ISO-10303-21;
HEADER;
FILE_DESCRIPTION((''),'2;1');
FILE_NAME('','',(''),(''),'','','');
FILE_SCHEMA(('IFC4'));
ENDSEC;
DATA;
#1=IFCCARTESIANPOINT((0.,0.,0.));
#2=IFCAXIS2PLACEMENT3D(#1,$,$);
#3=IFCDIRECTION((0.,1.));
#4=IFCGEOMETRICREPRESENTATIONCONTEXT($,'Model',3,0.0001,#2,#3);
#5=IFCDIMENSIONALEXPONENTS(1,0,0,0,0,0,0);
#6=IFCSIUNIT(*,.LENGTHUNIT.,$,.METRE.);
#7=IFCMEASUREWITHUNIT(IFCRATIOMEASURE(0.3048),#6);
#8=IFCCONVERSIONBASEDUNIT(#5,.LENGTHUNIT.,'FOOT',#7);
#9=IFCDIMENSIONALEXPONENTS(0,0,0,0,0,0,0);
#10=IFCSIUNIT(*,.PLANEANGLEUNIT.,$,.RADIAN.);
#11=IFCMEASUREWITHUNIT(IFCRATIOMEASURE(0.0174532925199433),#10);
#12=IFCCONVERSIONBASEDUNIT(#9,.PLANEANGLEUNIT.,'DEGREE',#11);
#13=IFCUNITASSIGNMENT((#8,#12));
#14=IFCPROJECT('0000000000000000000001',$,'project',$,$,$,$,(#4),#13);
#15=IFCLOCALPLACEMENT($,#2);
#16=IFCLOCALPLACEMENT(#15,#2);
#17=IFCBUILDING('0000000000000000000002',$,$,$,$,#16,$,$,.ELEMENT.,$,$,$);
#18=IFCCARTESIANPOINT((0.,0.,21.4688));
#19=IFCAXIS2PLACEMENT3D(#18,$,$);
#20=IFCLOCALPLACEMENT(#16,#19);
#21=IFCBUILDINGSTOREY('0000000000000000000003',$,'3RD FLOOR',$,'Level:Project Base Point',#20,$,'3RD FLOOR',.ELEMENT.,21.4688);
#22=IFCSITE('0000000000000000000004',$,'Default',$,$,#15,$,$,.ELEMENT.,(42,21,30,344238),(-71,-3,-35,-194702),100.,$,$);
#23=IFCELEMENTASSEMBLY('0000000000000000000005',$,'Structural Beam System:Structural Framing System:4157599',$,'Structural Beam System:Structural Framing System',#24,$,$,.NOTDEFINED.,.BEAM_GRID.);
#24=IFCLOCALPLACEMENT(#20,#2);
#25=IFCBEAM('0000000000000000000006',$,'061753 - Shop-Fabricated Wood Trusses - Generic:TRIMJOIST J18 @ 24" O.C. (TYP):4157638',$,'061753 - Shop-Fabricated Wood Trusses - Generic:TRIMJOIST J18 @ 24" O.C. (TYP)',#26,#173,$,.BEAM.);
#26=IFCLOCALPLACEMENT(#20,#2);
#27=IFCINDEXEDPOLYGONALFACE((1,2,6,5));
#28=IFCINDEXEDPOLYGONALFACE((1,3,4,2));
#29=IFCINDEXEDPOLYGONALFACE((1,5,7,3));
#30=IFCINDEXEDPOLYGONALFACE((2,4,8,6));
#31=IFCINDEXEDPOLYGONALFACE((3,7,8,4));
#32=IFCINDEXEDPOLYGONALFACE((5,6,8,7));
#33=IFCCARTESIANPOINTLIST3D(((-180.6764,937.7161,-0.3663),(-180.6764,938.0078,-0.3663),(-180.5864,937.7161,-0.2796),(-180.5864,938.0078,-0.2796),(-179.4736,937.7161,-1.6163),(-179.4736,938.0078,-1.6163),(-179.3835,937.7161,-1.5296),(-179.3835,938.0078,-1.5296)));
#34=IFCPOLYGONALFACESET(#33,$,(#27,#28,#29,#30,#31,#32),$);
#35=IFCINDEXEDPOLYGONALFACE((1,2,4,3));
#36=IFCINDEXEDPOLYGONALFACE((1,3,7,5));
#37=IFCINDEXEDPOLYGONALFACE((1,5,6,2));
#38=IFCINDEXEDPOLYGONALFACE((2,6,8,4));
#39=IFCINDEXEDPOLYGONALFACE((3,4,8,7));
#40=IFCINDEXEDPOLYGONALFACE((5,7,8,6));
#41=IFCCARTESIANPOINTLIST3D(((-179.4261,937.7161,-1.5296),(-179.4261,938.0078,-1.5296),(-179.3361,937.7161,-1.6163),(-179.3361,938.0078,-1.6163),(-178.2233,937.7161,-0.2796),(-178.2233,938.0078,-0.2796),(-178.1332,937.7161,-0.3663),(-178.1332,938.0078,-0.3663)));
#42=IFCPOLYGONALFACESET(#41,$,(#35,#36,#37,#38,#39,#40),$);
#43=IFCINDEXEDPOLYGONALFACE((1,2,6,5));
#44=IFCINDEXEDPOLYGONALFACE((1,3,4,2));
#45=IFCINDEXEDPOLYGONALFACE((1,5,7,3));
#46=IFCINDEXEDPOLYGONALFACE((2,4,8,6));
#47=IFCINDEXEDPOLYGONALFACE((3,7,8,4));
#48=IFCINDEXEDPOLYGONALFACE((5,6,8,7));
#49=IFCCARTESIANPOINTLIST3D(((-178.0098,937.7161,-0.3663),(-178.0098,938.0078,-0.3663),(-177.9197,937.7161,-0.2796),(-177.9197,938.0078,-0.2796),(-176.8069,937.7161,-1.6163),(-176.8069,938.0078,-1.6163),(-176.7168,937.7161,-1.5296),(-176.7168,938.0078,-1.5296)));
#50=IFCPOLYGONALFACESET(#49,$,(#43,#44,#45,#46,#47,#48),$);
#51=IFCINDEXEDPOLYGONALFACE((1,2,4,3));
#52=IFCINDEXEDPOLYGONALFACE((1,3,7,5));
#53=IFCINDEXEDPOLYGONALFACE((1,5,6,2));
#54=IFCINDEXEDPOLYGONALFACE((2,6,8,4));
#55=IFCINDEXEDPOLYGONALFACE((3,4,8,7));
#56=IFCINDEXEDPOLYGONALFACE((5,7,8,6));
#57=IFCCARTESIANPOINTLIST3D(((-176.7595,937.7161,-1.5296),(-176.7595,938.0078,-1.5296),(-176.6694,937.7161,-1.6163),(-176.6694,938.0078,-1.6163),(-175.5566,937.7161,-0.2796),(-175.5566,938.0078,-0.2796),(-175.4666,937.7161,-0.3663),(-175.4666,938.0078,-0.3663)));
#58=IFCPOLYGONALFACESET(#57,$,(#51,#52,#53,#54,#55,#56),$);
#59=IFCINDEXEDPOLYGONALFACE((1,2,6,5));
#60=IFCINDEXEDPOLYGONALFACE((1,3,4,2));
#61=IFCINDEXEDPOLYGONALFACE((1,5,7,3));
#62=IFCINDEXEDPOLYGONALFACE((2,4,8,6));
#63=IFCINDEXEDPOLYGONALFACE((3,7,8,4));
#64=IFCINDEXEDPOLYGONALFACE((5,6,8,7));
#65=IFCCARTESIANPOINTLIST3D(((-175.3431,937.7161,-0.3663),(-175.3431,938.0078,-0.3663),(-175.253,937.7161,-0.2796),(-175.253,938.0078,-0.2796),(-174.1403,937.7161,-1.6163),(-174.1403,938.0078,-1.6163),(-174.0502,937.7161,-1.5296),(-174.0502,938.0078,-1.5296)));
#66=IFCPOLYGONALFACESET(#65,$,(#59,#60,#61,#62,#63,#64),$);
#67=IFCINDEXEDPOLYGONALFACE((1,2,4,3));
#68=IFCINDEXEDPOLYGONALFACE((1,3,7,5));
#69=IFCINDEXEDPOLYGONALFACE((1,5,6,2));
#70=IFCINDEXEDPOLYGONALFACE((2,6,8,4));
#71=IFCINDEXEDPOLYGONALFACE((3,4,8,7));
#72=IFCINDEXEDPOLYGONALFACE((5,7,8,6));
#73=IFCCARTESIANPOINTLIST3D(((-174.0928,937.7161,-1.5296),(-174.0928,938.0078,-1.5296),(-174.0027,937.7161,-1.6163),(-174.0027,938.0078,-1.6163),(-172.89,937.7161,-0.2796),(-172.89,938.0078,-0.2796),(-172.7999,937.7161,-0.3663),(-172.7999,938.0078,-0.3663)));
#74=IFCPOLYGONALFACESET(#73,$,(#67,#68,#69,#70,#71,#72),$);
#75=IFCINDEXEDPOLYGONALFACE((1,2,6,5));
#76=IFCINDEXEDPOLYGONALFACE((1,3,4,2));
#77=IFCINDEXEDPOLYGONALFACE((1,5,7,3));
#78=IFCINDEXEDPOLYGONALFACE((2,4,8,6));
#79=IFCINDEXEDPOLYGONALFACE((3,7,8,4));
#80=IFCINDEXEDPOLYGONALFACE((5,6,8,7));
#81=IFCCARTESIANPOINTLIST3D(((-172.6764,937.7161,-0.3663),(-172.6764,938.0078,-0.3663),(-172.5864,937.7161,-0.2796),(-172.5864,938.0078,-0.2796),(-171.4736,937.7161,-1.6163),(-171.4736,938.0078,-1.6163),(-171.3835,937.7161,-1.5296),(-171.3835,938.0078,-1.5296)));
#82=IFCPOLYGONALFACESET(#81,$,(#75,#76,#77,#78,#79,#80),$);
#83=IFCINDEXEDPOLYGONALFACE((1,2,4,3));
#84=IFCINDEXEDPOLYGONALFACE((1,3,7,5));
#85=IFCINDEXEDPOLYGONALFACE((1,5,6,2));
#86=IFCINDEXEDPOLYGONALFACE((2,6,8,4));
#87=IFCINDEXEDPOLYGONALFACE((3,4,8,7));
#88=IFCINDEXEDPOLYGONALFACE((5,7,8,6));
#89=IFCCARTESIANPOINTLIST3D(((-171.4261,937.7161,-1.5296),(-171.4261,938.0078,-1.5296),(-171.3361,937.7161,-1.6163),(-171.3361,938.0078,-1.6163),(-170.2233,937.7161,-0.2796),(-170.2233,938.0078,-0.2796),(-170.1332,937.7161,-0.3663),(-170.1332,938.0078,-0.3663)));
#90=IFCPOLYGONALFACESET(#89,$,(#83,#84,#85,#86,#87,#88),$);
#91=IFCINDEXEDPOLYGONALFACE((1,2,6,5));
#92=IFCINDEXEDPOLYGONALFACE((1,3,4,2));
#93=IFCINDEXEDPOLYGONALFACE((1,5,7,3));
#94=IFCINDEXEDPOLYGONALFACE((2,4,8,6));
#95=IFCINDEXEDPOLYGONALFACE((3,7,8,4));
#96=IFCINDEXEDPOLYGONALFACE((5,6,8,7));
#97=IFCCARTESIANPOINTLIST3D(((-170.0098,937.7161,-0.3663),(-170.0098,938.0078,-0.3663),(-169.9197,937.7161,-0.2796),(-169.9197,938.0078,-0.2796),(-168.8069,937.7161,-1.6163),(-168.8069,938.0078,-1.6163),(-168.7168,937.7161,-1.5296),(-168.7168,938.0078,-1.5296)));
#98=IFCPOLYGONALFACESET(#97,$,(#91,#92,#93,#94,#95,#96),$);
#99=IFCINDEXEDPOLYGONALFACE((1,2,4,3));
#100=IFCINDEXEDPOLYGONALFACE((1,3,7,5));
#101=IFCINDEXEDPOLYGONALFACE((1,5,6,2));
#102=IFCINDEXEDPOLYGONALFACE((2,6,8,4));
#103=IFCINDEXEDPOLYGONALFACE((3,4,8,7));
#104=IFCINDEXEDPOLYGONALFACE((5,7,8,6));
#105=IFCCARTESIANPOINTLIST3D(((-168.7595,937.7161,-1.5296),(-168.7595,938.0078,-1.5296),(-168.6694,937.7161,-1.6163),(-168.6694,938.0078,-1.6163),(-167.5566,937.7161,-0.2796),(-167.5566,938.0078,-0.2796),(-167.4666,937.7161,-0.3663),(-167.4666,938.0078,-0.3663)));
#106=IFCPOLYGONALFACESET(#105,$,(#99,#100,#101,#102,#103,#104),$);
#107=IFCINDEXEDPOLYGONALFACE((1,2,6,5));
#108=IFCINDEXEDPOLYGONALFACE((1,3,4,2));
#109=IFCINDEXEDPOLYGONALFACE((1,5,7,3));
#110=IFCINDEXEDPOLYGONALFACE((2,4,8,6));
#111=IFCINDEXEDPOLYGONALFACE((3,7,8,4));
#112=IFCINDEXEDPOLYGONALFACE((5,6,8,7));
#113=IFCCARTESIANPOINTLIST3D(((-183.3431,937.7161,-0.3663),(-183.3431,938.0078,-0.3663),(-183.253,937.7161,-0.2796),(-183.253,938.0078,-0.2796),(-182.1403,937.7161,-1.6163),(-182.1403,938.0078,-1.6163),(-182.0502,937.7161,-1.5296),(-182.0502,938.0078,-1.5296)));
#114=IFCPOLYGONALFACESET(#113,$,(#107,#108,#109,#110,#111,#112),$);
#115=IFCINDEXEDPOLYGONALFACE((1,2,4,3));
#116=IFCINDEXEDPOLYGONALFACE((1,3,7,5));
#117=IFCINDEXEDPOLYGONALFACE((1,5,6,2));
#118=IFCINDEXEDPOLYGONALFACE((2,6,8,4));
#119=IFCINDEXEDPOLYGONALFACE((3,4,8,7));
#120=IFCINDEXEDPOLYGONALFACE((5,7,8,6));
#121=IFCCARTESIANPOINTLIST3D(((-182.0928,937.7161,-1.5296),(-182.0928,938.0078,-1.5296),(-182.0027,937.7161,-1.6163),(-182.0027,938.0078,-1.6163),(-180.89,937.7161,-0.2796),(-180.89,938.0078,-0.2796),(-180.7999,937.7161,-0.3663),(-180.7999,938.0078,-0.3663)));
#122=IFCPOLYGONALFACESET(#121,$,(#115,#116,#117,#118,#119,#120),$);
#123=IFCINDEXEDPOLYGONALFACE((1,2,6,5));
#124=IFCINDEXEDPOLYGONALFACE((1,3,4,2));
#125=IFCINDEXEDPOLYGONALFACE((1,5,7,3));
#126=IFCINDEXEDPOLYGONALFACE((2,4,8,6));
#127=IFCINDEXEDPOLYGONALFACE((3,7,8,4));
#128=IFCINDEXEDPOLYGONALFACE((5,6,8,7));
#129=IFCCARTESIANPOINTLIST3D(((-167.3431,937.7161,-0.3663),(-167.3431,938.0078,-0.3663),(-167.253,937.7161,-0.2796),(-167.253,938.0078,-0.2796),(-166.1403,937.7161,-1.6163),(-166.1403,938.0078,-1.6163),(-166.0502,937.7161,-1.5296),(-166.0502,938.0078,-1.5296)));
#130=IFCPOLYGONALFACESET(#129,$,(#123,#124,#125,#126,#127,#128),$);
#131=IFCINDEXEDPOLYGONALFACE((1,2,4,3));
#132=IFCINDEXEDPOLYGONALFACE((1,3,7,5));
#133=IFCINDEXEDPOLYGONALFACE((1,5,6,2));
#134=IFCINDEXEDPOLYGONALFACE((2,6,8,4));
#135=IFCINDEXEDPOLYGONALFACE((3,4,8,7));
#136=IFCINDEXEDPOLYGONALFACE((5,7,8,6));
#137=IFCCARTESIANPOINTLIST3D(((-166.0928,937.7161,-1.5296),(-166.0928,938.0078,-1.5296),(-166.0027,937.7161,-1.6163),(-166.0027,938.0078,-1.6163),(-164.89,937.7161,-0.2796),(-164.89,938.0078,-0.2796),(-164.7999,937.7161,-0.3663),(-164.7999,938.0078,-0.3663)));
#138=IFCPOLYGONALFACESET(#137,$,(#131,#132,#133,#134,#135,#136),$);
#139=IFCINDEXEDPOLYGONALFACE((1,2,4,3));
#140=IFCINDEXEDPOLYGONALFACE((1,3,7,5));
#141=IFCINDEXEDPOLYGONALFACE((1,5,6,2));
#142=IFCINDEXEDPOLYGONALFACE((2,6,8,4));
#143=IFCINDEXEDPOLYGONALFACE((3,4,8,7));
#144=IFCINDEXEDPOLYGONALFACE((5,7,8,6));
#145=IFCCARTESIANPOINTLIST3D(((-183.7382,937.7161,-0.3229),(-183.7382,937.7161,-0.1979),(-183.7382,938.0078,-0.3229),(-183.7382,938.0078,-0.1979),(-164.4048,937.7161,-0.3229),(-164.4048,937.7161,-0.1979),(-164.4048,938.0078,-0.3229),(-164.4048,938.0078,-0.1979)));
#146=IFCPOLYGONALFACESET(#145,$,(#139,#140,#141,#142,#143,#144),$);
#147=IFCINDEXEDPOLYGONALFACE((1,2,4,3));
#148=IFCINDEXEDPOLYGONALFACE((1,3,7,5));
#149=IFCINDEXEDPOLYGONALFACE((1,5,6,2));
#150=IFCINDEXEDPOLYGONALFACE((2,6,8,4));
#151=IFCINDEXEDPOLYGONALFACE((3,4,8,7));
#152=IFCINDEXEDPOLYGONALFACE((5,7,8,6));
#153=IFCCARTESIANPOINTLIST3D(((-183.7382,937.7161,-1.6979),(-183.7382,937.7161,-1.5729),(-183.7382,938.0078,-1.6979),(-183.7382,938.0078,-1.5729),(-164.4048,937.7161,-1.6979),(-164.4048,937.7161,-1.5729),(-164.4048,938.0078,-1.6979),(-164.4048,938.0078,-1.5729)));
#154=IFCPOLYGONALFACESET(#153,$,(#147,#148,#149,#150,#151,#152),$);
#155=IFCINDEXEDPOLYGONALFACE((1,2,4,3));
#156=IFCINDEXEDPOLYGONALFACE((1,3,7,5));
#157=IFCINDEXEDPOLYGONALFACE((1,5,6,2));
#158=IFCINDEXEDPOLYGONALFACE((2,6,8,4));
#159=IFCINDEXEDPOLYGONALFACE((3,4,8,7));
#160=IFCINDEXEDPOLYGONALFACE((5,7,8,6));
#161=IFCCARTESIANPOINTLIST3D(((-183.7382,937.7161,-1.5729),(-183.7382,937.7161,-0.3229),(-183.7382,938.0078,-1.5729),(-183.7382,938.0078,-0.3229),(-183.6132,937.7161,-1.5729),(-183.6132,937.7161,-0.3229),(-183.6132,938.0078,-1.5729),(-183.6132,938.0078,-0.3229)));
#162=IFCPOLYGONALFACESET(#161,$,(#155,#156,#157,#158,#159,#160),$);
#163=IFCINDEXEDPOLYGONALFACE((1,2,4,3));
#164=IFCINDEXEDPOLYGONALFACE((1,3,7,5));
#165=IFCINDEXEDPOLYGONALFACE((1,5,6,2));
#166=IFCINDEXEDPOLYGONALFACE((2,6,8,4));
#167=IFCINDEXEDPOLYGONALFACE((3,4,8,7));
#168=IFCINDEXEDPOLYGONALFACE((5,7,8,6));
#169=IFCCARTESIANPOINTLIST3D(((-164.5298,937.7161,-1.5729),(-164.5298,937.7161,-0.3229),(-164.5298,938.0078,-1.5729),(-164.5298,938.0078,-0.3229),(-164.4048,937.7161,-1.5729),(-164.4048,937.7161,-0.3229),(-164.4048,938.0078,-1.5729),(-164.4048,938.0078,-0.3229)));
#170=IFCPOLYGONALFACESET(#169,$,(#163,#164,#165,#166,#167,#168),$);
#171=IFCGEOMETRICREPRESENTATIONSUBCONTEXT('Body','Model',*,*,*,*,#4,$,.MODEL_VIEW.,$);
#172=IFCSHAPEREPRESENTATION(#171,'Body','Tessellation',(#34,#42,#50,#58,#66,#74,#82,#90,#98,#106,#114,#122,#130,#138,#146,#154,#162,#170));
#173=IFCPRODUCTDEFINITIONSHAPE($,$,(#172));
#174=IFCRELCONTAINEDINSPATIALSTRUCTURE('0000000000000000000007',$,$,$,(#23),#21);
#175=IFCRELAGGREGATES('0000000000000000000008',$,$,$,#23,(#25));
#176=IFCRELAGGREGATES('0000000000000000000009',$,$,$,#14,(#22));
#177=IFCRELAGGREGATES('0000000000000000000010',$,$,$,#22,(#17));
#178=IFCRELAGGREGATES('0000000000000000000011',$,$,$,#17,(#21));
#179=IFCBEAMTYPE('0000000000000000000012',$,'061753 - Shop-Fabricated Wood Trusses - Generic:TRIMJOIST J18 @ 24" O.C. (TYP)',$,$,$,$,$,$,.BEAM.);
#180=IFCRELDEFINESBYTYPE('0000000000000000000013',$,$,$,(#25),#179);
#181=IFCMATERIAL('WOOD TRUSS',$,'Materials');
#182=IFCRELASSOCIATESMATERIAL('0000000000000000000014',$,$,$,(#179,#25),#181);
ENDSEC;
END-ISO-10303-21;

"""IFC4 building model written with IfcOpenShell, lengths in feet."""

from ifc_helpers import new_model, entity, si_unit, converted_unit, direction, frame, frame_2d, origin, origin_2d_with_axis, place, context, subcontext, project, spatial, rectangle, extrude, source, transform, mapped, material, material_profile, profile_set, profile_usage, type_object, type_shapes, element, aggregate, save


model = new_model("IFC4")

# Units and contexts
model_context = context("Model", 3, precision=0.0001, world=origin(), true_north=direction((0.0, 1.0)))
body_context = subcontext(model_context, "Body", "Model", "MODEL_VIEW")
ifc_project = project(units=[converted_unit("LENGTHUNIT", "FOOT", entity("IfcRatioMeasure", 0.3048), si_unit("LENGTHUNIT", "METRE"), dimensions=[1, 0, 0, 0, 0, 0, 0]), converted_unit("PLANEANGLEUNIT", "DEGREE", entity("IfcRatioMeasure", 0.0174532925199433), si_unit("PLANEANGLEUNIT", "RADIAN"), dimensions=[0, 0, 0, 0, 0, 0, 0])], contexts=[model_context])

# Site, building, storey
site_placement = place(None, origin())
site = spatial("IfcSite", under=ifc_project, at=site_placement, Name="Default", CompositionType="ELEMENT", RefLatitude=(42, 21, 30, 344238), RefLongitude=(-71, -3, -35, -194702), RefElevation=100.0)
building_placement = place(site_placement, origin())
building = spatial("IfcBuilding", under=site, at=building_placement, CompositionType="ELEMENT")
storey_placement = place(building_placement, frame((0.0, 0.0, 21.4688)))
storey = spatial("IfcBuildingStorey", under=building, at=storey_placement, Name="3RD FLOOR", ObjectType="Level:Project Base Point", LongName="3RD FLOOR", CompositionType="ELEMENT", Elevation=21.4688)

# Element assembly, beam
ifc_material = material(Name="WOOD TRUSS", Category="Materials")
ifc_material_profile_1 = material_profile(ifc_material, rectangle(XDim=1.7347, YDim=0.125, at=frame_2d((0.0, 0.0), x_axis=(1.0, 0.0))), Name="TRIMJOIST J18 @ 24\" O.C. (TYP)")
ifc_material_profile_2 = material_profile(ifc_material, rectangle(XDim=1.7347, YDim=0.125, at=frame_2d((0.0, 0.0), x_axis=(1.0, 0.0))), Name="TRIMJOIST J18 @ 24\" O.C. (TYP)")
ifc_material_profile_3 = material_profile(ifc_material, rectangle(XDim=1.7347, YDim=0.125, at=frame_2d((0.0, 0.0), x_axis=(1.0, 0.0))), Name="TRIMJOIST J18 @ 24\" O.C. (TYP)")
ifc_material_profile_4 = material_profile(ifc_material, rectangle(XDim=1.7347, YDim=0.125, at=frame_2d((0.0, 0.0), x_axis=(1.0, 0.0))), Name="TRIMJOIST J18 @ 24\" O.C. (TYP)")
ifc_material_profile_5 = material_profile(ifc_material, rectangle(XDim=1.7347, YDim=0.125, at=frame_2d((0.0, 0.0), x_axis=(1.0, 0.0))), Name="TRIMJOIST J18 @ 24\" O.C. (TYP)")
ifc_material_profile_6 = material_profile(ifc_material, rectangle(XDim=1.7347, YDim=0.125, at=frame_2d((0.0, 0.0), x_axis=(1.0, 0.0))), Name="TRIMJOIST J18 @ 24\" O.C. (TYP)")
ifc_material_profile_7 = material_profile(ifc_material, rectangle(XDim=1.7347, YDim=0.125, at=frame_2d((0.0, 0.0), x_axis=(1.0, 0.0))), Name="TRIMJOIST J18 @ 24\" O.C. (TYP)")
ifc_material_profile_8 = material_profile(ifc_material, rectangle(XDim=1.7347, YDim=0.125, at=frame_2d((0.0, 0.0), x_axis=(1.0, 0.0))), Name="TRIMJOIST J18 @ 24\" O.C. (TYP)")
ifc_material_profile_9 = material_profile(ifc_material, rectangle(XDim=1.7347, YDim=0.125, at=frame_2d((0.0, 0.0), x_axis=(1.0, 0.0))), Name="TRIMJOIST J18 @ 24\" O.C. (TYP)")
ifc_material_profile_10 = material_profile(ifc_material, rectangle(XDim=1.7347, YDim=0.125, at=origin_2d_with_axis()), Name="TRIMJOIST J18 @ 24\" O.C. (TYP)")
ifc_material_profile_11 = material_profile(ifc_material, rectangle(XDim=0.125, YDim=0.2917, at=origin_2d_with_axis()), Name="TRIMJOIST J18 @ 24\" O.C. (TYP)")
ifc_material_profile_12 = material_profile(ifc_material, rectangle(XDim=0.125, YDim=0.2917, at=origin_2d_with_axis()), Name="TRIMJOIST J18 @ 24\" O.C. (TYP)")
ifc_material_profile_13 = material_profile(ifc_material, rectangle(XDim=1.25, YDim=0.2917, at=origin_2d_with_axis()), Name="TRIMJOIST J18 @ 24\" O.C. (TYP)")
ifc_material_profile_14 = material_profile(ifc_material, rectangle(XDim=1.25, YDim=0.2917, at=origin_2d_with_axis()), Name="TRIMJOIST J18 @ 24\" O.C. (TYP)")
ifc_profile_set = profile_set([ifc_material_profile_1, ifc_material_profile_2, ifc_material_profile_3, ifc_material_profile_4, ifc_material_profile_5, ifc_material_profile_6, ifc_material_profile_7, ifc_material_profile_8, ifc_material_profile_9, ifc_material_profile_10, ifc_material_profile_11, ifc_material_profile_12, ifc_material_profile_13, ifc_material_profile_14], Name="TRIMJOIST J18 @ 24\" O.C. (TYP)")
assembly_1_placement = place(storey_placement, origin())
assembly_1 = element("IfcElementAssembly", 1, at=assembly_1_placement, inside=storey, Name="Structural Beam System:Structural Framing System:4157599", ObjectType="Structural Beam System:Structural Framing System", AssemblyPlace="NOTDEFINED", PredefinedType="BEAM_GRID")
beam_type_1 = type_object("IfcBeamType", Name="061753 - Shop-Fabricated Wood Trusses - Generic:TRIMJOIST J18 @ 24\" O.C. (TYP)", PredefinedType="BEAM", material=ifc_profile_set)
shared_shape_1 = source(origin(), body_context, "Body", "SweptSolid", [
    extrude(rectangle(XDim=1.7347, YDim=0.125, at=frame_2d((0.0, 0.0), x_axis=(1.0, 0.0))), frame((5.9585, -0.1458, 0.0), z_axis=(0.0, 1.0, 0.0), x_axis=(0.693383, 0.0, 0.720569)), (0.0, 0.0, 1.0), 0.2917),
    extrude(rectangle(XDim=1.7347, YDim=0.125, at=origin_2d_with_axis()), frame((4.7082, -0.1458, 0.0), z_axis=(0.0, 1.0, 0.0), x_axis=(0.693383, 0.0, -0.720569)), (0.0, 0.0, 1.0), 0.2917),
    extrude(rectangle(XDim=1.7347, YDim=0.125, at=frame_2d((0.0, 0.0), x_axis=(1.0, 0.0))), frame((3.2918, -0.1458, 0.0), z_axis=(0.0, 1.0, 0.0), x_axis=(0.693383, 0.0, 0.720569)), (0.0, 0.0, 1.0), 0.2917),
    extrude(rectangle(XDim=1.7347, YDim=0.125, at=frame_2d((0.0, 0.0), x_axis=(1.0, 0.0))), frame((2.0415, -0.1458, 0.0), z_axis=(0.0, 1.0, 0.0), x_axis=(0.693383, 0.0, -0.720569)), (0.0, 0.0, 1.0), 0.2917),
    extrude(rectangle(XDim=1.7347, YDim=0.125, at=frame_2d((0.0, 0.0), x_axis=(1.0, 0.0))), frame((0.6251, -0.1458, 0.0), z_axis=(0.0, 1.0, 0.0), x_axis=(0.693383, 0.0, 0.720569)), (0.0, 0.0, 1.0), 0.2917),
    extrude(rectangle(XDim=1.7347, YDim=0.125, at=frame_2d((0.0, 0.0), x_axis=(1.0, 0.0))), frame((-0.6251, -0.1458, 0.0), z_axis=(0.0, 1.0, 0.0), x_axis=(0.693383, 0.0, -0.720569)), (0.0, 0.0, 1.0), 0.2917),
    extrude(rectangle(XDim=1.7347, YDim=0.125, at=frame_2d((0.0, 0.0), x_axis=(1.0, 0.0))), frame((-2.0415, -0.1458, 0.0), z_axis=(0.0, 1.0, 0.0), x_axis=(0.693383, 0.0, 0.720569)), (0.0, 0.0, 1.0), 0.2917),
    extrude(rectangle(XDim=1.7347, YDim=0.125, at=origin_2d_with_axis()), frame((-3.2918, -0.1458, 0.0), z_axis=(0.0, 1.0, 0.0), x_axis=(0.693383, 0.0, -0.720569)), (0.0, 0.0, 1.0), 0.2917),
    extrude(rectangle(XDim=1.7347, YDim=0.125, at=frame_2d((0.0, 0.0), x_axis=(1.0, 0.0))), frame((-4.7082, -0.1458, 0.0), z_axis=(0.0, 1.0, 0.0), x_axis=(0.693383, 0.0, 0.720569)), (0.0, 0.0, 1.0), 0.2917),
    extrude(rectangle(XDim=1.7347, YDim=0.125, at=frame_2d((0.0, 0.0), x_axis=(1.0, 0.0))), frame((-5.9585, -0.1458, 0.0), z_axis=(0.0, 1.0, 0.0), x_axis=(0.693383, 0.0, -0.720569)), (0.0, 0.0, 1.0), 0.2917),
    extrude(rectangle(XDim=1.7347, YDim=0.125, at=frame_2d((0.0, 0.0), x_axis=(1.0, 0.0))), frame((8.6251, -0.1458, 0.0), z_axis=(0.0, 1.0, 0.0), x_axis=(0.693383, 0.0, 0.720569)), (0.0, 0.0, 1.0), 0.2917),
    extrude(rectangle(XDim=1.7347, YDim=0.125, at=origin_2d_with_axis()), frame((7.3749, -0.1458, 0.0), z_axis=(0.0, 1.0, 0.0), x_axis=(0.693383, 0.0, -0.720569)), (0.0, 0.0, 1.0), 0.2917),
    extrude(rectangle(XDim=1.7347, YDim=0.125, at=frame_2d((0.0, 0.0), x_axis=(1.0, 0.0))), frame((-7.3749, -0.1458, 0.0), z_axis=(0.0, 1.0, 0.0), x_axis=(0.693383, 0.0, 0.720569)), (0.0, 0.0, 1.0), 0.2917),
    extrude(rectangle(XDim=1.7347, YDim=0.125, at=origin_2d_with_axis()), frame((-8.6251, -0.1458, 0.0), z_axis=(0.0, 1.0, 0.0), x_axis=(0.693383, 0.0, -0.720569)), (0.0, 0.0, 1.0), 0.2917),
    extrude(rectangle(XDim=0.125, YDim=0.2917, at=origin_2d_with_axis()), frame((-9.6667, 0.0, 0.6875), z_axis=(1.0, 0.0, 0.0), x_axis=(0.0, 0.0, -1.0)), (0.0, 0.0, 1.0), 19.3333),
    extrude(rectangle(XDim=0.125, YDim=0.2917, at=origin_2d_with_axis()), frame((-9.6667, 0.0, -0.6875), z_axis=(1.0, 0.0, 0.0), x_axis=(0.0, 0.0, -1.0)), (0.0, 0.0, 1.0), 19.3333),
    extrude(rectangle(XDim=1.25, YDim=0.2917, at=origin_2d_with_axis()), frame((9.5417, 0.0, 0.0), z_axis=(1.0, 0.0, 0.0), x_axis=(0.0, 0.0, -1.0)), (0.0, 0.0, 1.0), 0.125),
    extrude(rectangle(XDim=1.25, YDim=0.2917, at=origin_2d_with_axis()), frame((-9.6667, 0.0, 0.0), z_axis=(1.0, 0.0, 0.0), x_axis=(0.0, 0.0, -1.0)), (0.0, 0.0, 1.0), 0.125),
])
type_shapes(beam_type_1, [shared_shape_1])
ifc_profile_usage_1 = profile_usage(ifc_profile_set, cardinal=8)
beam_1_placement = place(assembly_1_placement, frame((-174.0715, 937.8619, -0.9479), z_axis=(0.0, 0.0, 1.0), x_axis=(-1.0, 0.0, 0.0)))
beam_1 = element("IfcBeam", 2, at=beam_1_placement, type_object=beam_type_1, material=ifc_profile_usage_1, Name="061753 - Shop-Fabricated Wood Trusses - Generic:TRIMJOIST J18 @ 24\" O.C. (TYP):4157638", ObjectType="061753 - Shop-Fabricated Wood Trusses - Generic:TRIMJOIST J18 @ 24\" O.C. (TYP)", PredefinedType="BEAM", context=body_context, shape_type="MappedRepresentation", body=[
    mapped(shared_shape_1, transform((0.0, 0.0, 0.0), scale=1.0)),
])
aggregate(assembly_1, [beam_1])

save(model, "model.ifc")
